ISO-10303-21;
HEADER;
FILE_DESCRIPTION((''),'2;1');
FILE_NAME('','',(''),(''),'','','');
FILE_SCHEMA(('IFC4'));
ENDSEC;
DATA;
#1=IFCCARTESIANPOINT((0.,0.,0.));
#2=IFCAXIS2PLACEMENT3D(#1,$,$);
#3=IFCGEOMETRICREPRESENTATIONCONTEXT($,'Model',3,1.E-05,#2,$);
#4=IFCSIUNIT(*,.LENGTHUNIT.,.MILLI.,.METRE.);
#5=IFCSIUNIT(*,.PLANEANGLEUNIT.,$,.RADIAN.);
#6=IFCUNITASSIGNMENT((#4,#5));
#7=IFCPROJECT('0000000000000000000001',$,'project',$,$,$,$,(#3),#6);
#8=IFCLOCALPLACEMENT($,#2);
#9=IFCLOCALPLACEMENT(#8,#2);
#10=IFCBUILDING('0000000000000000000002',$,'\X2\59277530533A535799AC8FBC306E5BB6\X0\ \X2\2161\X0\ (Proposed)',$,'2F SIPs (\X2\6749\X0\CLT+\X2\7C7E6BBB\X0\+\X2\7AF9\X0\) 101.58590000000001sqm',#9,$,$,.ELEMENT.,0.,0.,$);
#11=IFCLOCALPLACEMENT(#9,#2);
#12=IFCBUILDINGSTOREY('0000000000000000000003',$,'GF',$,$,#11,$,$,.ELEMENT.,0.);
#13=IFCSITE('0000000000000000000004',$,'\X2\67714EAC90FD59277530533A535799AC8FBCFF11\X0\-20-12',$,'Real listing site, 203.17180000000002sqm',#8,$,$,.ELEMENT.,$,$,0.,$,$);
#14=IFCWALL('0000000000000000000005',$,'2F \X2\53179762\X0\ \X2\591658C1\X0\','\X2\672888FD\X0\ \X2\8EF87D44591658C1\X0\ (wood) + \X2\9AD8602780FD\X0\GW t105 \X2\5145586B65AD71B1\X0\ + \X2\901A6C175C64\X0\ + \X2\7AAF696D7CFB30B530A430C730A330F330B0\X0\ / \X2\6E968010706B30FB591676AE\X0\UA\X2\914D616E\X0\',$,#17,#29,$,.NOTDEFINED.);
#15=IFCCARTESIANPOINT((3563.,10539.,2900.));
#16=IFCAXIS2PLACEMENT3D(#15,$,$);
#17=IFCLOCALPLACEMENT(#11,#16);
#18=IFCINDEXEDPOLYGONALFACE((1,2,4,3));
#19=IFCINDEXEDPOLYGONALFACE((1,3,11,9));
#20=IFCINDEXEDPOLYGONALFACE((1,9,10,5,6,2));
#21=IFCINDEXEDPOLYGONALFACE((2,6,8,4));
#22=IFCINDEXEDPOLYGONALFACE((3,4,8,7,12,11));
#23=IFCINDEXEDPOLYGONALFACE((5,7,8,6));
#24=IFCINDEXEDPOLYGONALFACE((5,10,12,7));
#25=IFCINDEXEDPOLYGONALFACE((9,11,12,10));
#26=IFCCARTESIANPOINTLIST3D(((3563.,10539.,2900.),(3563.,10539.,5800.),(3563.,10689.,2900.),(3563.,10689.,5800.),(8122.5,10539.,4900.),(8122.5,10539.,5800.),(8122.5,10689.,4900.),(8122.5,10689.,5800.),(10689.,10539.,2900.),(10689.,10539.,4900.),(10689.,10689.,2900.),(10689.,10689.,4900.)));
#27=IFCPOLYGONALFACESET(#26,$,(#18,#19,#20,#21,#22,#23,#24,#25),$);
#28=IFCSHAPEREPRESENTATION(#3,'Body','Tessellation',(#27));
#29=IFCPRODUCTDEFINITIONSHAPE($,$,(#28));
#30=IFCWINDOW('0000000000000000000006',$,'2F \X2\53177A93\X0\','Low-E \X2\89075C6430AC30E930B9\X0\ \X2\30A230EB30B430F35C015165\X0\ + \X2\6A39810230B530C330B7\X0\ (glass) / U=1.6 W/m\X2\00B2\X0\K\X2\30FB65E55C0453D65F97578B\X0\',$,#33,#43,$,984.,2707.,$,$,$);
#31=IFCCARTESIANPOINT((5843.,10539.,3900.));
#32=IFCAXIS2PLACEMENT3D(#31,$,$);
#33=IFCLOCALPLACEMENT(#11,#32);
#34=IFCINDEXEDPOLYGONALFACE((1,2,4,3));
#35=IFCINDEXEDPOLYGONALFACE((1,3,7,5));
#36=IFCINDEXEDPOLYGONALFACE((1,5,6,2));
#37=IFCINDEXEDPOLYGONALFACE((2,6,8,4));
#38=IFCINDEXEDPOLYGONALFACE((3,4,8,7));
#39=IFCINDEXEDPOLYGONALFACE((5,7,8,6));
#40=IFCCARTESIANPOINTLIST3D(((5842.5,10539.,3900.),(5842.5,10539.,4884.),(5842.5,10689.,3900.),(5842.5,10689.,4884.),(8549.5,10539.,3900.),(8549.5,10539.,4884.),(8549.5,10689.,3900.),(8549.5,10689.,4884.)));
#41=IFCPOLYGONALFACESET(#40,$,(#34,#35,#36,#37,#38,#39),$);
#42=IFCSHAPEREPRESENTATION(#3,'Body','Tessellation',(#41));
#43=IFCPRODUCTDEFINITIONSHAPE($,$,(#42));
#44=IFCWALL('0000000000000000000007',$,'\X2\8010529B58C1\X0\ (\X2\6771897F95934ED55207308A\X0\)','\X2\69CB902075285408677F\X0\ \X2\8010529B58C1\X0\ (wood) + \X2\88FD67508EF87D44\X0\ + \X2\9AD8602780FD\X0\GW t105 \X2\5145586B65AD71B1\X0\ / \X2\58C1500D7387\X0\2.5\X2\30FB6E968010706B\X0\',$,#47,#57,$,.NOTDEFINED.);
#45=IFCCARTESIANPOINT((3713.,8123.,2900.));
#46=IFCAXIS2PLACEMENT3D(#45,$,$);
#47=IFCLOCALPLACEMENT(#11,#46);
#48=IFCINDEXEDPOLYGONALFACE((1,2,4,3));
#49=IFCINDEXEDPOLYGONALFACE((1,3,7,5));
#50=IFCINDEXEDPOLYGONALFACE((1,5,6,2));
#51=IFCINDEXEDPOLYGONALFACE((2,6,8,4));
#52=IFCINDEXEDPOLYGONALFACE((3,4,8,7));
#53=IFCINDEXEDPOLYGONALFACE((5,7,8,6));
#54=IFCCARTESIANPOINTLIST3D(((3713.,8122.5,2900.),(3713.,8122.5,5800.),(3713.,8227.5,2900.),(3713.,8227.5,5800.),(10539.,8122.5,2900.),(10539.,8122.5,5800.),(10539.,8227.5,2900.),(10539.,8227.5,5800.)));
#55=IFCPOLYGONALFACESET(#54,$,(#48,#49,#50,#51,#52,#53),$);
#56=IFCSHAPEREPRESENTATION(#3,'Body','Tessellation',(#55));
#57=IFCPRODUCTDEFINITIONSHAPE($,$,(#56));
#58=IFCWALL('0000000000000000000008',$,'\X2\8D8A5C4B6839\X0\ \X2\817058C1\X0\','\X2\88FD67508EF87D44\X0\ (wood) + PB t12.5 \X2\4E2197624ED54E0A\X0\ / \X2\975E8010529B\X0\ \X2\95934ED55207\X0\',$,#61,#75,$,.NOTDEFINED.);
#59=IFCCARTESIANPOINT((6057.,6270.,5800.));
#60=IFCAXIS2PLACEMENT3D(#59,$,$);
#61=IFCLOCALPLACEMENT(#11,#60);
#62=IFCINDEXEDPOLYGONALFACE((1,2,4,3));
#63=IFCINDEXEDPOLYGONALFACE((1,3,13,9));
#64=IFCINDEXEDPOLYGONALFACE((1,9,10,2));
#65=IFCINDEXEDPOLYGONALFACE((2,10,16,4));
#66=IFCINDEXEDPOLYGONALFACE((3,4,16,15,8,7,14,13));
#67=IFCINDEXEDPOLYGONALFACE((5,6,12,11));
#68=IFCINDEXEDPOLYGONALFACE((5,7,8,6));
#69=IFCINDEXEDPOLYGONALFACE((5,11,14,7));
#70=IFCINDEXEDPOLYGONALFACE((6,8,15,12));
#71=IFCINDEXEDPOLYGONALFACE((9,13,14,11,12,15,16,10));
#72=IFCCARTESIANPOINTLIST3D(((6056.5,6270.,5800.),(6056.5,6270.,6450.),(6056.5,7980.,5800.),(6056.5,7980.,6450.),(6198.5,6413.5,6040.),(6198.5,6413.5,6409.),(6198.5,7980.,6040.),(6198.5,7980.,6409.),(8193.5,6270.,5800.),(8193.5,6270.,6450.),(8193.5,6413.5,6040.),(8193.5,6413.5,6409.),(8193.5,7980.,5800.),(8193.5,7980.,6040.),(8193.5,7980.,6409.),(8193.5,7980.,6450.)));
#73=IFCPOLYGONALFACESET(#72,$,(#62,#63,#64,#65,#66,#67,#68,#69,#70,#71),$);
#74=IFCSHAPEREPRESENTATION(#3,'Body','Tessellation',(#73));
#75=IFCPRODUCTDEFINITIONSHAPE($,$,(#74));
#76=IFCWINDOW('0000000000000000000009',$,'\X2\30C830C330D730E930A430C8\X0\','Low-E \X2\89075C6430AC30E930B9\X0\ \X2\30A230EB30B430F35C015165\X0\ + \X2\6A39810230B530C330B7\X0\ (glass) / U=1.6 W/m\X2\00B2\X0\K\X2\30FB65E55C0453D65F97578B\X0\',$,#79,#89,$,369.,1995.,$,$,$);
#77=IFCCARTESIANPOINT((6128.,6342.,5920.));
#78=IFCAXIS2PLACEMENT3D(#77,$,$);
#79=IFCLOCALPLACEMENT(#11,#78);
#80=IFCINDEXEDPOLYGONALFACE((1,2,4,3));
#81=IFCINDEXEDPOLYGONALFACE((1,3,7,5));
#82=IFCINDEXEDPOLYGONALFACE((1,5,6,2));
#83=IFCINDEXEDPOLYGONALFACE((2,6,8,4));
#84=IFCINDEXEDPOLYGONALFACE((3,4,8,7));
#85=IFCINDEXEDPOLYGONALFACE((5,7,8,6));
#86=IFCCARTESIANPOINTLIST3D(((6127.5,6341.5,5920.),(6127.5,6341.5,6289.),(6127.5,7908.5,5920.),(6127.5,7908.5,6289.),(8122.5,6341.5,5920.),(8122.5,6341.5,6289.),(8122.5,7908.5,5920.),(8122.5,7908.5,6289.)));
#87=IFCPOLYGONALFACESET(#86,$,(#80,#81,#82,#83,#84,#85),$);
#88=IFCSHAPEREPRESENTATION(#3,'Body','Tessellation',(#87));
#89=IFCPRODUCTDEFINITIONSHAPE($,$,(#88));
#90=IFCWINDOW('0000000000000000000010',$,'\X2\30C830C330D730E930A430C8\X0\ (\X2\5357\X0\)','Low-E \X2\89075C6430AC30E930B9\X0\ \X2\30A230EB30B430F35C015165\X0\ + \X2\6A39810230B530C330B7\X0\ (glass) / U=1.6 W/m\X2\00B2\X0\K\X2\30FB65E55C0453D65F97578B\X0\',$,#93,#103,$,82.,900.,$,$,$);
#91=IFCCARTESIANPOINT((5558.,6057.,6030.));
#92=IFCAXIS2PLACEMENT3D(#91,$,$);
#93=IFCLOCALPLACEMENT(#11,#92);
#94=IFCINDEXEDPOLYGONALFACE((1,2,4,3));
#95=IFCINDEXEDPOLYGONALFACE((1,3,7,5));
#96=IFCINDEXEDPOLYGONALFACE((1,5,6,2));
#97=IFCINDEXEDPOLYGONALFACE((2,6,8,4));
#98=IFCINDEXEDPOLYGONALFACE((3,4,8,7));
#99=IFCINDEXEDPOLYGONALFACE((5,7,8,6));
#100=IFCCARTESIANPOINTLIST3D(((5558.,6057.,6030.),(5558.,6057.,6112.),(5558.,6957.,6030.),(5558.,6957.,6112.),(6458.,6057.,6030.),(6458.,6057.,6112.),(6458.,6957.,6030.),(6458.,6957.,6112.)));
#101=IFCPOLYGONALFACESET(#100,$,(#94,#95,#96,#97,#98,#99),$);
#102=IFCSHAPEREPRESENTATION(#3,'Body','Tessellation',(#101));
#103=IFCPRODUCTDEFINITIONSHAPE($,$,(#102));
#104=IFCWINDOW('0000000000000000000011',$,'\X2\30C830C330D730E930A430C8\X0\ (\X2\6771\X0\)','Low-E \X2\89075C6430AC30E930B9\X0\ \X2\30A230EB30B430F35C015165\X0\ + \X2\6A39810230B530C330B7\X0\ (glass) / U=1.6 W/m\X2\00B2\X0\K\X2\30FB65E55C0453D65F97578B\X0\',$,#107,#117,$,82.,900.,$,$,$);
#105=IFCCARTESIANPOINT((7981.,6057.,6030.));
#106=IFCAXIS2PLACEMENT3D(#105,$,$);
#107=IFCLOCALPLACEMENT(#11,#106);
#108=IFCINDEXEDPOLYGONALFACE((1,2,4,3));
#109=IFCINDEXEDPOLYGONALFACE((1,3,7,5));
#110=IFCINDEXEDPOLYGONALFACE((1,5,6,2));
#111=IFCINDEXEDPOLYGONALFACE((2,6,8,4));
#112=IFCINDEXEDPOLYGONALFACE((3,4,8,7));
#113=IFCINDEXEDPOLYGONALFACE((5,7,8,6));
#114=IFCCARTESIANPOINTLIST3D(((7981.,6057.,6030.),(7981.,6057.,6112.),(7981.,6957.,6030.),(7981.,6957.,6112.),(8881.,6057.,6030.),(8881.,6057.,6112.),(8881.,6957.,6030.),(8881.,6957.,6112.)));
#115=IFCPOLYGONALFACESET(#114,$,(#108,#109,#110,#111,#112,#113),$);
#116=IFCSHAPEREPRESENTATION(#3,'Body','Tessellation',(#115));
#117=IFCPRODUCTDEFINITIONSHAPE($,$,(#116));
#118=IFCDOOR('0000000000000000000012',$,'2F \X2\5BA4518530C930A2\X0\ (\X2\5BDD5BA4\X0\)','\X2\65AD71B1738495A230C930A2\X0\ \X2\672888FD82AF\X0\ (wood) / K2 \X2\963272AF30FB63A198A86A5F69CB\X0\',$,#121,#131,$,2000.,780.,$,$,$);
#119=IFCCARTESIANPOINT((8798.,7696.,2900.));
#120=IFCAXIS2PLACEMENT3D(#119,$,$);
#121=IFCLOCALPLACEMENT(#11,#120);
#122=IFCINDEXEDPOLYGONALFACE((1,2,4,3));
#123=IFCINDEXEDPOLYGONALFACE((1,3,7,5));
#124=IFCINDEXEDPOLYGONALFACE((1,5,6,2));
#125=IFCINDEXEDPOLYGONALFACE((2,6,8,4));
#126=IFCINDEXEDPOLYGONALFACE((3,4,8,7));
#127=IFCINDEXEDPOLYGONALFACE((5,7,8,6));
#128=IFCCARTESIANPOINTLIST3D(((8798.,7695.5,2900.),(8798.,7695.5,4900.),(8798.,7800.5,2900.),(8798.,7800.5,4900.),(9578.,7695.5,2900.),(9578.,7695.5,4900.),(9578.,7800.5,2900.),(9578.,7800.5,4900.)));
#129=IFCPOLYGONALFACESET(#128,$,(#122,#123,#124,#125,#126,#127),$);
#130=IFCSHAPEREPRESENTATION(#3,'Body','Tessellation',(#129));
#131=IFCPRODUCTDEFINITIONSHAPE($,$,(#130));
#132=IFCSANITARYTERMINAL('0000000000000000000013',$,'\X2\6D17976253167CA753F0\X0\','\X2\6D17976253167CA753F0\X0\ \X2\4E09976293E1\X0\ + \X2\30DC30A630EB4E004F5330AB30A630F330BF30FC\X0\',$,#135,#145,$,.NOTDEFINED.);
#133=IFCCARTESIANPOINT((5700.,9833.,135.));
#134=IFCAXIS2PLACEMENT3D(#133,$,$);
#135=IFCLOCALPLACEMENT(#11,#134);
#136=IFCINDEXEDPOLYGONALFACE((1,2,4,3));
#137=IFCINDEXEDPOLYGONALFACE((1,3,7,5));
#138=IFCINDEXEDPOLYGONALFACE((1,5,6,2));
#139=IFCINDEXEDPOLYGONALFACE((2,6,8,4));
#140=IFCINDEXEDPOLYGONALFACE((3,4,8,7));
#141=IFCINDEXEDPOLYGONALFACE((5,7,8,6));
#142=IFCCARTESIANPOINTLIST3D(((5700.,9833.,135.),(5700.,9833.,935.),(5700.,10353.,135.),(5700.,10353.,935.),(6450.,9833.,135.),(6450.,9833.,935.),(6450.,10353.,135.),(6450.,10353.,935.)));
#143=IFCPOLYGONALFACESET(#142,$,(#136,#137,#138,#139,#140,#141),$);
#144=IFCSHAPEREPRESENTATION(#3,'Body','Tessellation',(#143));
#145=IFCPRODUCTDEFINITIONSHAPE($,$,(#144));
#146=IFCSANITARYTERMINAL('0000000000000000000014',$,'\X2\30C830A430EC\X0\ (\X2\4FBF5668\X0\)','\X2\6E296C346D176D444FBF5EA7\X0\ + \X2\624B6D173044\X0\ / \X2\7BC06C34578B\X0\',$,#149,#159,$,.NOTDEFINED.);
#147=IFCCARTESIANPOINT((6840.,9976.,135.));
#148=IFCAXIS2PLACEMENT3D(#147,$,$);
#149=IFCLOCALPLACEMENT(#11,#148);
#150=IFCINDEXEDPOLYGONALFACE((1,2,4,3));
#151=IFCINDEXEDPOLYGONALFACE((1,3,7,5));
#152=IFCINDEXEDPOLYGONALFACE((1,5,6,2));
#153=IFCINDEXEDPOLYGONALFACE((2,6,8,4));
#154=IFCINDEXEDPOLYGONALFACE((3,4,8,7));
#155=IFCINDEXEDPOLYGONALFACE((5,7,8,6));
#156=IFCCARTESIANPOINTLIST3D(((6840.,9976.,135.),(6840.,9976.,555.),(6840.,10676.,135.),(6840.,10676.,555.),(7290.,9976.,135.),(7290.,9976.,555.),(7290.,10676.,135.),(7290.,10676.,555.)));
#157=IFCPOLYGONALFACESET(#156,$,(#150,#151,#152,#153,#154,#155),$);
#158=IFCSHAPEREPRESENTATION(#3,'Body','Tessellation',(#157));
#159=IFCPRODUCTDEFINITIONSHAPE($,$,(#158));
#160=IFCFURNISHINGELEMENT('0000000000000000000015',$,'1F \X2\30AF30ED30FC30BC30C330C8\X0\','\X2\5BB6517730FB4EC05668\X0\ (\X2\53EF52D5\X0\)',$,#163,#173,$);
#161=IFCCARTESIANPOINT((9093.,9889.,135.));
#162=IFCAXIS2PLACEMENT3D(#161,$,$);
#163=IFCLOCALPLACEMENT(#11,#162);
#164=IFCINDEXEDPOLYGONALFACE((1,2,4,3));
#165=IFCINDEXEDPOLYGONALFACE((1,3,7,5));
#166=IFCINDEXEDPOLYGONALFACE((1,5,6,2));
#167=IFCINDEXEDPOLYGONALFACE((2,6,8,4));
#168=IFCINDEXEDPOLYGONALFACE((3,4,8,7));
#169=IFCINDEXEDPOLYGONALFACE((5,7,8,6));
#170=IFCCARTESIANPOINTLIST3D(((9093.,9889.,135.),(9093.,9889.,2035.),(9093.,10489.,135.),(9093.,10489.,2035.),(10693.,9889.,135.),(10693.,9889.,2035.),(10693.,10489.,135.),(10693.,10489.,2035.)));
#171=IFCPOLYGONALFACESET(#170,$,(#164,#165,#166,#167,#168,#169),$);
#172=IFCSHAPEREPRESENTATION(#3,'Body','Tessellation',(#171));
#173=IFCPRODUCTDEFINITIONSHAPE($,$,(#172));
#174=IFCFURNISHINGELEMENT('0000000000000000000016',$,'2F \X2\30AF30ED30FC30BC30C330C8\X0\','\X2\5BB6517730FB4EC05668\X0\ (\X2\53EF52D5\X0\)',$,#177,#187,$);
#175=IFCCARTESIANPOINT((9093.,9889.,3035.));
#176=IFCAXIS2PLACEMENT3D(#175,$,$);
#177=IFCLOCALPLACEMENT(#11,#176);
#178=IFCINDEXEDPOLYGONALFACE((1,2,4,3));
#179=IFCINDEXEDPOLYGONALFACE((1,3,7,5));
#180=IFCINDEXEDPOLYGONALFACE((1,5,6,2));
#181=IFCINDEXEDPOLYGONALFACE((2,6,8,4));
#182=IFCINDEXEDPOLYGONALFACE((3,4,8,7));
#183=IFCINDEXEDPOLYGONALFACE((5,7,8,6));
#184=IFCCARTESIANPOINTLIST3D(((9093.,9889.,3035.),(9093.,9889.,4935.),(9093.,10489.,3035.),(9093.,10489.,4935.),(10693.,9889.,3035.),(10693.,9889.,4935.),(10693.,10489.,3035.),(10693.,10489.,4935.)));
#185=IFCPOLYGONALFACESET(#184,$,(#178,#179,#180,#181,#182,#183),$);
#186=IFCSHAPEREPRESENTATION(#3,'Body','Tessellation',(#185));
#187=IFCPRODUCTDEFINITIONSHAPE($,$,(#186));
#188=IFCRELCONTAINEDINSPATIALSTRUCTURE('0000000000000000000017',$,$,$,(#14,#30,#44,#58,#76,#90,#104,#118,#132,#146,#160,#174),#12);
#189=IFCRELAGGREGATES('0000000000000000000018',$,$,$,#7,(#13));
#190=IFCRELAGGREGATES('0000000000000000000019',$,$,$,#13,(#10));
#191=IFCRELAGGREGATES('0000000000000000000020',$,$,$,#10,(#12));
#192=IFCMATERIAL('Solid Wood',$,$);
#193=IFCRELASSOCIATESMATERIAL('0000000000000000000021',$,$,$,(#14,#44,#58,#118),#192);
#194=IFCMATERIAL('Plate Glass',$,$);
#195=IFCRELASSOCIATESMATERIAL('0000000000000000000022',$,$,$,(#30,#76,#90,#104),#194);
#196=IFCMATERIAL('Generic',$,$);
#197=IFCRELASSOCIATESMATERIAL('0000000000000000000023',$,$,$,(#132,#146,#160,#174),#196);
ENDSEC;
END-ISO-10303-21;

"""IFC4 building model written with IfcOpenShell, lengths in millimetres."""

from ifc_helpers import new_model, si_unit, frame, frame_2d, origin, place, context, project, spatial, rectangle, extrude, material, element, fill, save


model = new_model("IFC4")

# Units and contexts
model_context = context("Model", 3, precision=1e-05, world=origin())
ifc_project = project(units=[si_unit("LENGTHUNIT", "METRE", prefix="MILLI"), si_unit("PLANEANGLEUNIT", "RADIAN")], contexts=[model_context])

# Site, building, storey
site_placement = place(None, origin())
site = spatial("IfcSite", under=ifc_project, at=site_placement, Name="東京都大田区南馬込１-20-12", ObjectType="Real listing site, 203.17180000000002sqm", CompositionType="ELEMENT", RefElevation=0.0)
building_placement = place(site_placement, origin())
building = spatial("IfcBuilding", under=site, at=building_placement, Name="大田区南馬込の家 Ⅱ (Proposed)", ObjectType="2F SIPs (杉CLT+籾殻+竹) 101.58590000000001sqm", CompositionType="ELEMENT", ElevationOfRefHeight=0.0, ElevationOfTerrain=0.0)
storey_placement = place(building_placement, origin())
storey = spatial("IfcBuildingStorey", under=building, at=storey_placement, Name="GF", CompositionType="ELEMENT", Elevation=0.0)

# Wall, opening, window
ifc_material_1 = material(Name="Solid Wood")
wall_1_placement = place(storey_placement, frame((3563.0, 10539.0, 2900.0)))
wall_1 = element("IfcWall", 1, at=wall_1_placement, inside=storey, material=ifc_material_1, Name="2F 北面 外壁", Description="木製 軸組外壁 (wood) + 高性能GW t105 充填断熱 + 通気層 + 窯業系サイディング / 準耐火・外皮UA配慮", PredefinedType="NOTDEFINED", context=model_context, shape_type="SweptSolid", body=[
    extrude(rectangle(XDim=7126.0, YDim=150.0, at=frame_2d((3563.0, 75.0))), frame((3563.0, 10539.0, 2900.0)), (0.0, 0.0, 1.0), 2900.0),
])
opening_1_placement = place(storey_placement, frame((5843.0, 10539.0, 3900.0)))
opening_1 = element("IfcOpeningElement", 2, at=opening_1_placement, cuts=wall_1, PredefinedType="NOTDEFINED", context=model_context, shape_type="SweptSolid", body=[
    extrude(rectangle(XDim=2707.0, YDim=150.0, at=frame_2d((1353.0, 75.0))), frame((5843.0, 10539.0, 3900.0)), (0.0, 0.0, 1.0), 984.0),
])
ifc_material_2 = material(Name="Plate Glass")
window_1_placement = place(storey_placement, frame((5843.0, 10539.0, 3900.0)))
window_1 = element("IfcWindow", 3, at=window_1_placement, inside=storey, material=ifc_material_2, Name="2F 北窓", Description="Low-E 複層ガラス アルゴン封入 + 樹脂サッシ (glass) / U=1.6 W/m²K・日射取得型", OverallHeight=984.0, OverallWidth=2707.0, context=model_context, shape_type="SweptSolid", body=[
    extrude(rectangle(XDim=2707.0, YDim=150.0, at=frame_2d((1353.0, 75.0))), frame((5843.0, 10539.0, 3900.0)), (0.0, 0.0, 1.0), 984.0),
])
fill(opening_1, window_1)

# Wall
wall_2_placement = place(storey_placement, frame((3713.0, 8123.0, 2900.0)))
element("IfcWall", 4, at=wall_2_placement, inside=storey, material=ifc_material_1, Name="耐力壁 (東西間仕切り)", Description="構造用合板 耐力壁 (wood) + 製材軸組 + 高性能GW t105 充填断熱 / 壁倍率2.5・準耐火", PredefinedType="NOTDEFINED", context=model_context, shape_type="SweptSolid", body=[
    extrude(rectangle(XDim=6826.0, YDim=105.0, at=frame_2d((3413.0, 52.0))), frame((3713.0, 8123.0, 2900.0)), (0.0, 0.0, 1.0), 2900.0),
])

# Wall, openings, windows
wall_3_placement = place(storey_placement, frame((6057.0, 6270.0, 5800.0)))
wall_3 = element("IfcWall", 5, at=wall_3_placement, inside=storey, material=ifc_material_1, Name="越屋根 腰壁", Description="製材軸組 (wood) + PB t12.5 両面仕上 / 非耐力 間仕切", PredefinedType="NOTDEFINED", context=model_context, shape_type="SweptSolid", body=[
    extrude(rectangle(XDim=2137.0, YDim=1710.0, at=frame_2d((1068.0, 855.0))), frame((6057.0, 6270.0, 5800.0)), (0.0, 0.0, 1.0), 650.0),
])
opening_2_placement = place(storey_placement, frame((6128.0, 6342.0, 5920.0)))
opening_2 = element("IfcOpeningElement", 6, at=opening_2_placement, cuts=wall_3, PredefinedType="NOTDEFINED", context=model_context, shape_type="SweptSolid", body=[
    extrude(rectangle(XDim=1995.0, YDim=1567.0, at=frame_2d((997.0, 783.0))), frame((6128.0, 6342.0, 5920.0)), (0.0, 0.0, 1.0), 369.0),
])
opening_3_placement = place(storey_placement, frame((5558.0, 6057.0, 6030.0)))
opening_3 = element("IfcOpeningElement", 7, at=opening_3_placement, cuts=wall_3, PredefinedType="NOTDEFINED", context=model_context, shape_type="SweptSolid", body=[
    extrude(rectangle(XDim=900.0, YDim=900.0, at=frame_2d((450.0, 450.0))), frame((5558.0, 6057.0, 6030.0)), (0.0, 0.0, 1.0), 82.0),
])
opening_4_placement = place(storey_placement, frame((7981.0, 6057.0, 6030.0)))
opening_4 = element("IfcOpeningElement", 8, at=opening_4_placement, cuts=wall_3, PredefinedType="NOTDEFINED", context=model_context, shape_type="SweptSolid", body=[
    extrude(rectangle(XDim=900.0, YDim=900.0, at=frame_2d((450.0, 450.0))), frame((7981.0, 6057.0, 6030.0)), (0.0, 0.0, 1.0), 82.0),
])
window_2_placement = place(storey_placement, frame((6128.0, 6342.0, 5920.0)))
window_2 = element("IfcWindow", 9, at=window_2_placement, inside=storey, material=ifc_material_2, Name="トップライト", Description="Low-E 複層ガラス アルゴン封入 + 樹脂サッシ (glass) / U=1.6 W/m²K・日射取得型", OverallHeight=369.0, OverallWidth=1995.0, context=model_context, shape_type="SweptSolid", body=[
    extrude(rectangle(XDim=1995.0, YDim=1567.0, at=frame_2d((997.0, 783.0))), frame((6128.0, 6342.0, 5920.0)), (0.0, 0.0, 1.0), 369.0),
])
fill(opening_2, window_2)
window_3_placement = place(storey_placement, frame((5558.0, 6057.0, 6030.0)))
window_3 = element("IfcWindow", 10, at=window_3_placement, inside=storey, material=ifc_material_2, Name="トップライト (南)", Description="Low-E 複層ガラス アルゴン封入 + 樹脂サッシ (glass) / U=1.6 W/m²K・日射取得型", OverallHeight=82.0, OverallWidth=900.0, context=model_context, shape_type="SweptSolid", body=[
    extrude(rectangle(XDim=900.0, YDim=900.0, at=frame_2d((450.0, 450.0))), frame((5558.0, 6057.0, 6030.0)), (0.0, 0.0, 1.0), 82.0),
])
fill(opening_3, window_3)
window_4_placement = place(storey_placement, frame((7981.0, 6057.0, 6030.0)))
window_4 = element("IfcWindow", 11, at=window_4_placement, inside=storey, material=ifc_material_2, Name="トップライト (東)", Description="Low-E 複層ガラス アルゴン封入 + 樹脂サッシ (glass) / U=1.6 W/m²K・日射取得型", OverallHeight=82.0, OverallWidth=900.0, context=model_context, shape_type="SweptSolid", body=[
    extrude(rectangle(XDim=900.0, YDim=900.0, at=frame_2d((450.0, 450.0))), frame((7981.0, 6057.0, 6030.0)), (0.0, 0.0, 1.0), 82.0),
])
fill(opening_4, window_4)

# Door
door_placement = place(storey_placement, frame((8798.0, 7696.0, 2900.0)))
element("IfcDoor", 12, at=door_placement, inside=storey, material=ifc_material_1, Name="2F 室内ドア (寝室)", Description="断熱玄関ドア 木製芯 (wood) / K2 防犯・採風機構", OverallHeight=2000.0, OverallWidth=780.0, context=model_context, shape_type="SweptSolid", body=[
    extrude(rectangle(XDim=780.0, YDim=105.0, at=frame_2d((390.0, 52.0))), frame((8798.0, 7696.0, 2900.0)), (0.0, 0.0, 1.0), 2000.0),
])

# Sanitary terminals
ifc_material_3 = material(Name="Generic")
sanitary_terminal_1_placement = place(storey_placement, frame((5700.0, 9833.0, 135.0)))
element("IfcSanitaryTerminal", 13, at=sanitary_terminal_1_placement, inside=storey, material=ifc_material_3, Name="洗面化粧台", Description="洗面化粧台 三面鏡 + ボウル一体カウンター", PredefinedType="NOTDEFINED", context=model_context, shape_type="SweptSolid", body=[
    extrude(rectangle(XDim=750.0, YDim=520.0, at=frame_2d((375.0, 260.0))), frame((5700.0, 9833.0, 135.0)), (0.0, 0.0, 1.0), 800.0),
])
sanitary_terminal_2_placement = place(storey_placement, frame((6840.0, 9976.0, 135.0)))
element("IfcSanitaryTerminal", 14, at=sanitary_terminal_2_placement, inside=storey, material=ifc_material_3, Name="トイレ (便器)", Description="温水洗浄便座 + 手洗い / 節水型", PredefinedType="NOTDEFINED", context=model_context, shape_type="SweptSolid", body=[
    extrude(rectangle(XDim=450.0, YDim=700.0, at=frame_2d((225.0, 350.0))), frame((6840.0, 9976.0, 135.0)), (0.0, 0.0, 1.0), 420.0),
])

# Furnishing elements
furnishing_1_placement = place(storey_placement, frame((9093.0, 9889.0, 135.0)))
element("IfcFurnishingElement", 15, at=furnishing_1_placement, inside=storey, material=ifc_material_3, Name="1F クローゼット", Description="家具・什器 (可動)", context=model_context, shape_type="SweptSolid", body=[
    extrude(rectangle(XDim=1600.0, YDim=600.0, at=frame_2d((800.0, 300.0))), frame((9093.0, 9889.0, 135.0)), (0.0, 0.0, 1.0), 1900.0),
])
furnishing_2_placement = place(storey_placement, frame((9093.0, 9889.0, 3035.0)))
element("IfcFurnishingElement", 16, at=furnishing_2_placement, inside=storey, material=ifc_material_3, Name="2F クローゼット", Description="家具・什器 (可動)", context=model_context, shape_type="SweptSolid", body=[
    extrude(rectangle(XDim=1600.0, YDim=600.0, at=frame_2d((800.0, 300.0))), frame((9093.0, 9889.0, 3035.0)), (0.0, 0.0, 1.0), 1900.0),
])

save(model, "model.ifc")
